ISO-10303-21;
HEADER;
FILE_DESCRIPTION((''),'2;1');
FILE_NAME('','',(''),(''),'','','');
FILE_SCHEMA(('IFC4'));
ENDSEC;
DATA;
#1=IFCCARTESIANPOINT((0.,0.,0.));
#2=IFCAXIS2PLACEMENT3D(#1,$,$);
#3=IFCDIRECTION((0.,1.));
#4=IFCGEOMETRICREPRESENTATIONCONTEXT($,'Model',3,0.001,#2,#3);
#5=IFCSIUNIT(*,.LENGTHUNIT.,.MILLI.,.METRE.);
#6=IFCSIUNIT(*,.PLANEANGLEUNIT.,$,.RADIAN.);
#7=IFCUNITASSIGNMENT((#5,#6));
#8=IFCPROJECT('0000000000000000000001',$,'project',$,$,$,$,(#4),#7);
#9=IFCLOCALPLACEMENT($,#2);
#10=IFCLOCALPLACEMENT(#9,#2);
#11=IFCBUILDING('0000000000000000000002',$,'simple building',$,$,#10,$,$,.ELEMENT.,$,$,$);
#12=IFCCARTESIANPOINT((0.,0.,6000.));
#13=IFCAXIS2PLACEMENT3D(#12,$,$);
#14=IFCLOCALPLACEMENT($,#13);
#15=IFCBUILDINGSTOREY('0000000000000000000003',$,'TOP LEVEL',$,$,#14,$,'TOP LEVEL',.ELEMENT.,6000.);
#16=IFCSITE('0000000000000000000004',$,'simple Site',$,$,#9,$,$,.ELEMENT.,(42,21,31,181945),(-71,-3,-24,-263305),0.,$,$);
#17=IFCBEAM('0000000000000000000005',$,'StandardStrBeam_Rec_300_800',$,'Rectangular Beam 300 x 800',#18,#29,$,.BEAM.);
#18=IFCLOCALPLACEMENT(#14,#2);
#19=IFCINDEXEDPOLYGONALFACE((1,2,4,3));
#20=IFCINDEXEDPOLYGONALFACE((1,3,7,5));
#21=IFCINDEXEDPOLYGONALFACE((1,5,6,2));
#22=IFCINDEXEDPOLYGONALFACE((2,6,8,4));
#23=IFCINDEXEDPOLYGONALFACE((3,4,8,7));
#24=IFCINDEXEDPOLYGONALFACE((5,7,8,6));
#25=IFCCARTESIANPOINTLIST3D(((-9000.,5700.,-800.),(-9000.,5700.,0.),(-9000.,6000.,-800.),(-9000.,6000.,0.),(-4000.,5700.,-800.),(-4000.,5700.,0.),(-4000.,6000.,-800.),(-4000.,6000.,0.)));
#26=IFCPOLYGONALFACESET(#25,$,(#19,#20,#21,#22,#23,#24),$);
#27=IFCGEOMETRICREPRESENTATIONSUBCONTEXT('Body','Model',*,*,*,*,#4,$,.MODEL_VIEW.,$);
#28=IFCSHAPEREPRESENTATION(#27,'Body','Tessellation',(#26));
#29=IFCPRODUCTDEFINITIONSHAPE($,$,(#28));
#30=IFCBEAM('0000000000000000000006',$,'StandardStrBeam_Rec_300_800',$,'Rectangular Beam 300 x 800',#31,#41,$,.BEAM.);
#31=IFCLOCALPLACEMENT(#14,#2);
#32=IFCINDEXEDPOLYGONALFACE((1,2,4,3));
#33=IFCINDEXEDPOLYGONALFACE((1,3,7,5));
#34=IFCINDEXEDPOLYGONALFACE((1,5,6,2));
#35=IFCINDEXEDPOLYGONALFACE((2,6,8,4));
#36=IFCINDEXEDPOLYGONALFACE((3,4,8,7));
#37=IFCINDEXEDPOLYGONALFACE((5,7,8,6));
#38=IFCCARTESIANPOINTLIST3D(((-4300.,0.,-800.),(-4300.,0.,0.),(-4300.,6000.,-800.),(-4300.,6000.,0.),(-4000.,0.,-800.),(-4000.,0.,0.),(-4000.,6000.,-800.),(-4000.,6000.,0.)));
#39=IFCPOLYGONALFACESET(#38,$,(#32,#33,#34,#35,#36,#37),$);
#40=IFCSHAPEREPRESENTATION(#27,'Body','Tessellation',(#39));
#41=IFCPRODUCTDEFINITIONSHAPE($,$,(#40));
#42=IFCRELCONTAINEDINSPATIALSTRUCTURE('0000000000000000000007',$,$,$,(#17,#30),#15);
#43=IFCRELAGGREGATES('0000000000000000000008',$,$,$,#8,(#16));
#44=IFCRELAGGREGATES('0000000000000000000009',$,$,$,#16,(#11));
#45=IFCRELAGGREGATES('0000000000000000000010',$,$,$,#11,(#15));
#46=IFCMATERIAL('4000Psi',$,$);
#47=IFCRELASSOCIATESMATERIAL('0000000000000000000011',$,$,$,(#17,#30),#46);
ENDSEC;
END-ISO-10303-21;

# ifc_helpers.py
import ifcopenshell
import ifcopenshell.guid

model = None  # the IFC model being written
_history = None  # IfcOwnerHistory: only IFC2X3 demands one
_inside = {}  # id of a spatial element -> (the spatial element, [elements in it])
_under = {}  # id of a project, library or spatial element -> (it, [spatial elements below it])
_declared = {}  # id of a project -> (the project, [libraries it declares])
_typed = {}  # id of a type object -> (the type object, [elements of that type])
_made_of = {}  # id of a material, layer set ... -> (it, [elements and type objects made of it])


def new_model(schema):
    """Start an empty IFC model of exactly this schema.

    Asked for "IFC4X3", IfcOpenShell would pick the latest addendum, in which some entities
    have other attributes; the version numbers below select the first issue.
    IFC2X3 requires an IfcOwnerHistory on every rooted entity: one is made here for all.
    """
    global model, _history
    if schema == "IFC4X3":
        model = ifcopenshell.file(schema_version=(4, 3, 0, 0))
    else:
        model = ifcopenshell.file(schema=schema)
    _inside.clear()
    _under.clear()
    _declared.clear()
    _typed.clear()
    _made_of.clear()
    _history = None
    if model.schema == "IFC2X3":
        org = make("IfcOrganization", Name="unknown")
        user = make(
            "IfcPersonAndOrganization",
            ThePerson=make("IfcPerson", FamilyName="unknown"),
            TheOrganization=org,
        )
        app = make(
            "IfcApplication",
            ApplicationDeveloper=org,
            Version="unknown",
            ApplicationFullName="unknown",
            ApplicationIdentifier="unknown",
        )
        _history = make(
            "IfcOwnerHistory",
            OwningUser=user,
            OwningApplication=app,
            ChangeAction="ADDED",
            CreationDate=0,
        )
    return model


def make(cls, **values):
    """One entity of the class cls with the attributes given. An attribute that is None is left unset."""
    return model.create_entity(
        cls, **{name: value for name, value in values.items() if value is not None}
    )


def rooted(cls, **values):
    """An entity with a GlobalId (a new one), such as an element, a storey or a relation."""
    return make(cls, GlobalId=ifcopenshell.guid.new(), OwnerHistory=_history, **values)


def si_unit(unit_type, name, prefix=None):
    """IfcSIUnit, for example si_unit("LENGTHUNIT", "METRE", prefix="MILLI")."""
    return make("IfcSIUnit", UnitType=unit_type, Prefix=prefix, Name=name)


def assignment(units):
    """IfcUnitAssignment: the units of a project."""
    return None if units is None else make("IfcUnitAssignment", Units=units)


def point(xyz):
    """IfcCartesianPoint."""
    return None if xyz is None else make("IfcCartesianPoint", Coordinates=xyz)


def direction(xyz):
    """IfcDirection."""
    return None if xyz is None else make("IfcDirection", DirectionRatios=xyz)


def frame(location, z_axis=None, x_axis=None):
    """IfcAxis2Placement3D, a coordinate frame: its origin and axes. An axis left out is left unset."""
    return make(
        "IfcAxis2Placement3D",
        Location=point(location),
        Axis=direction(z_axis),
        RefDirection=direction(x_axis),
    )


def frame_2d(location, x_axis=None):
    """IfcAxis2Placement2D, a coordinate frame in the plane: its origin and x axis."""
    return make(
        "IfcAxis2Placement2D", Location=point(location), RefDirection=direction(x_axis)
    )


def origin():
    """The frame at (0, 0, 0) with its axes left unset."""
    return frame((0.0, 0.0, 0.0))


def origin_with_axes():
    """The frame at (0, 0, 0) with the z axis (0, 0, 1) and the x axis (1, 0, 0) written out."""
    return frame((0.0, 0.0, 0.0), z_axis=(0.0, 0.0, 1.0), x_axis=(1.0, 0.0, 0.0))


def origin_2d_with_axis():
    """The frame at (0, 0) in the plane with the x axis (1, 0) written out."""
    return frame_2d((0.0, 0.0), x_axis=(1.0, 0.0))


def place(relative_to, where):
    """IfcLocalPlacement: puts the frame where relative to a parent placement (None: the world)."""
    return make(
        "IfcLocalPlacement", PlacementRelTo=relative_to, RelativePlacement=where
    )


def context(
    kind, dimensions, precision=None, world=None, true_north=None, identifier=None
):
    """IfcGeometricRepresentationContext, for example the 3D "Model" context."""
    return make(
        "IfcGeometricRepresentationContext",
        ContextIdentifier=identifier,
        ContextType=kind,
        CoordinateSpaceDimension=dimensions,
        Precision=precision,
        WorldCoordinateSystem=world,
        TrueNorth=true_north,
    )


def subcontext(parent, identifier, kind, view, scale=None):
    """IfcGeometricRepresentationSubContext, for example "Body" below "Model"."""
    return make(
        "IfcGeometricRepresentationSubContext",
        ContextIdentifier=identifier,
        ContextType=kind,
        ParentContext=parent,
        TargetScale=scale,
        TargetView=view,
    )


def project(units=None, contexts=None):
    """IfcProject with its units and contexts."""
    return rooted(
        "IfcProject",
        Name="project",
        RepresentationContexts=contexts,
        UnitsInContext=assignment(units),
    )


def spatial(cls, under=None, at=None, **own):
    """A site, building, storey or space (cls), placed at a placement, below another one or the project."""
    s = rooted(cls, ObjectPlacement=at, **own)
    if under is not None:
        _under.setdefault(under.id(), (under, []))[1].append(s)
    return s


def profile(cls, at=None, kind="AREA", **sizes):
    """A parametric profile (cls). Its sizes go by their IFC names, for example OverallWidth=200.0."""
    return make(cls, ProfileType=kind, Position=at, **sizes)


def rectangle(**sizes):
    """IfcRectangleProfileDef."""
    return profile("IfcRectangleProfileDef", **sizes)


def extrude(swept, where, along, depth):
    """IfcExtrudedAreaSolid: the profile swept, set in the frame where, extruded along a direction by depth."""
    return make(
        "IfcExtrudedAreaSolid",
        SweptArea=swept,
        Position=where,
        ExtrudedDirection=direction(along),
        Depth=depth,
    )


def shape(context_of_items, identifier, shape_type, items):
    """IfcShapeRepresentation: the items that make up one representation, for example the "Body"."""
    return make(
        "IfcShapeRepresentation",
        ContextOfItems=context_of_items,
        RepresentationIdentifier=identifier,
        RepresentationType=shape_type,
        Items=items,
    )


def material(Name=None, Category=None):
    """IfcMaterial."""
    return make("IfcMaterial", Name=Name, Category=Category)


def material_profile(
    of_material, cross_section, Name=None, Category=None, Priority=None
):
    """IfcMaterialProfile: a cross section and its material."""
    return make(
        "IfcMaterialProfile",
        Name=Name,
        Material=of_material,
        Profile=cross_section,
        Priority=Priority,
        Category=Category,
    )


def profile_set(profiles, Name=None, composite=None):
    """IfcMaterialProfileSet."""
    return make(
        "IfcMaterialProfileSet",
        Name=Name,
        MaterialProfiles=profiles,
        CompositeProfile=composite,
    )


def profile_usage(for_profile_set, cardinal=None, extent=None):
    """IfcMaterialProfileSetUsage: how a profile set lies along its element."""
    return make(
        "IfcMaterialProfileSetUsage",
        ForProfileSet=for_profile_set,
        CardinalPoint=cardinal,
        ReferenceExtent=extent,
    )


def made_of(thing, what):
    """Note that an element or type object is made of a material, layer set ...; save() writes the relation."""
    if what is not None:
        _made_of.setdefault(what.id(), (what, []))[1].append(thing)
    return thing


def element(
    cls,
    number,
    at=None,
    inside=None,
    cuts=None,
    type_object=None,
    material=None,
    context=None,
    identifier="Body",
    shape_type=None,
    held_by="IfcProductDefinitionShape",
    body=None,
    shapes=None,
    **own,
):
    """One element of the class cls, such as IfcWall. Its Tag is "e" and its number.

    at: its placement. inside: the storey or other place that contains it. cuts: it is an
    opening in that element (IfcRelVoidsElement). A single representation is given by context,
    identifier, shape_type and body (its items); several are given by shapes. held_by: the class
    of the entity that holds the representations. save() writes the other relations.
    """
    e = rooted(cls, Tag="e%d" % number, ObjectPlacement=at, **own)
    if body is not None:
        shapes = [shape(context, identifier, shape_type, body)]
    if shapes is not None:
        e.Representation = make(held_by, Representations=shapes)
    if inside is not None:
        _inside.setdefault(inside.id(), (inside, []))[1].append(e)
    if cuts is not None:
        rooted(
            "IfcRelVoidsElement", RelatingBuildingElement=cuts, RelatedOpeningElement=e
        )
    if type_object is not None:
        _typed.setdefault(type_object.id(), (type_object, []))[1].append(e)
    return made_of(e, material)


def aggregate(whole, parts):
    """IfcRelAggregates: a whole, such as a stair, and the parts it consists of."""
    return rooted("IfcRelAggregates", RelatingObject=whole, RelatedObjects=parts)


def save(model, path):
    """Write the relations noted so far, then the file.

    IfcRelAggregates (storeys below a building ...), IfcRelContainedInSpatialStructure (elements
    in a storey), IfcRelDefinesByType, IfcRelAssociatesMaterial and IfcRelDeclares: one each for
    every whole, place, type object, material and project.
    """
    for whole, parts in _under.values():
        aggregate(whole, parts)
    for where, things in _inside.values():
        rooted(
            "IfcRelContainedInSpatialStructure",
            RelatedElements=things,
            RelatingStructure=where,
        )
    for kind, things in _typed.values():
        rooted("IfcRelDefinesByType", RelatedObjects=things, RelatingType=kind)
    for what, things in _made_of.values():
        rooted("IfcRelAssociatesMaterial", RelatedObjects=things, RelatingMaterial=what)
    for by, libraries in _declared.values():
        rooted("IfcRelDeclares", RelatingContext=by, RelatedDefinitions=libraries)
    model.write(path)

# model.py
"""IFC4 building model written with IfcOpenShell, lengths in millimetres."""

from ifc_helpers import new_model, si_unit, direction, frame, origin, origin_with_axes, origin_2d_with_axis, place, context, subcontext, project, spatial, rectangle, extrude, material, material_profile, profile_set, profile_usage, element, save


model = new_model("IFC4")

# Units and contexts
model_context = context("Model", 3, precision=0.001, world=origin(), true_north=direction((0.0, 1.0)))
body_context = subcontext(model_context, "Body", "Model", "MODEL_VIEW")
ifc_project = project(units=[si_unit("LENGTHUNIT", "METRE", prefix="MILLI"), si_unit("PLANEANGLEUNIT", "RADIAN")], contexts=[model_context])

# Site, building, storey
site_placement = place(None, origin())
site = spatial("IfcSite", under=ifc_project, at=site_placement, Name="simple Site", CompositionType="ELEMENT", RefLatitude=(42, 21, 31, 181945), RefLongitude=(-71, -3, -24, -263305), RefElevation=0.0)
building_placement = place(site_placement, origin())
building = spatial("IfcBuilding", under=site, at=building_placement, Name="simple building", CompositionType="ELEMENT")
storey_placement = place(None, frame((0.0, 0.0, 6000.0)))
storey = spatial("IfcBuildingStorey", under=building, at=storey_placement, Name="TOP LEVEL", LongName="TOP LEVEL", CompositionType="ELEMENT", Elevation=6000.0)

# Beams
ifc_material = material(Name="4000Psi")
ifc_material_profile = material_profile(ifc_material, rectangle(XDim=300.0, YDim=800.0, at=origin_2d_with_axis()))
ifc_profile_set = profile_set([ifc_material_profile])
ifc_profile_usage_1 = profile_usage(ifc_profile_set, cardinal=7)
beam_1_placement = place(None, frame((-9000.0, 5850.0, 5600.0), z_axis=(1.0, 0.0, 0.0), x_axis=(0.0, -1.0, 0.0)))
element("IfcBeam", 1, at=beam_1_placement, inside=storey, material=ifc_profile_usage_1, Name="StandardStrBeam_Rec_300_800", ObjectType="Rectangular Beam 300 x 800", PredefinedType="BEAM", context=body_context, shape_type="SweptSolid", body=[
    extrude(rectangle(XDim=300.0, YDim=800.0, at=origin_2d_with_axis()), origin_with_axes(), (0.0, 0.0, 1.0), 5000.0),
])
ifc_profile_usage_2 = profile_usage(ifc_profile_set, cardinal=9)
beam_2_placement = place(None, frame((-4150.0, 0.0, 5600.0), z_axis=(0.0, 1.0, 0.0), x_axis=(1.0, 0.0, 0.0)))
element("IfcBeam", 2, at=beam_2_placement, inside=storey, material=ifc_profile_usage_2, Name="StandardStrBeam_Rec_300_800", ObjectType="Rectangular Beam 300 x 800", PredefinedType="BEAM", context=body_context, shape_type="SweptSolid", body=[
    extrude(rectangle(XDim=300.0, YDim=800.0, at=origin_2d_with_axis()), origin_with_axes(), (0.0, 0.0, 1.0), 6000.0),
])

save(model, "model.ifc")
